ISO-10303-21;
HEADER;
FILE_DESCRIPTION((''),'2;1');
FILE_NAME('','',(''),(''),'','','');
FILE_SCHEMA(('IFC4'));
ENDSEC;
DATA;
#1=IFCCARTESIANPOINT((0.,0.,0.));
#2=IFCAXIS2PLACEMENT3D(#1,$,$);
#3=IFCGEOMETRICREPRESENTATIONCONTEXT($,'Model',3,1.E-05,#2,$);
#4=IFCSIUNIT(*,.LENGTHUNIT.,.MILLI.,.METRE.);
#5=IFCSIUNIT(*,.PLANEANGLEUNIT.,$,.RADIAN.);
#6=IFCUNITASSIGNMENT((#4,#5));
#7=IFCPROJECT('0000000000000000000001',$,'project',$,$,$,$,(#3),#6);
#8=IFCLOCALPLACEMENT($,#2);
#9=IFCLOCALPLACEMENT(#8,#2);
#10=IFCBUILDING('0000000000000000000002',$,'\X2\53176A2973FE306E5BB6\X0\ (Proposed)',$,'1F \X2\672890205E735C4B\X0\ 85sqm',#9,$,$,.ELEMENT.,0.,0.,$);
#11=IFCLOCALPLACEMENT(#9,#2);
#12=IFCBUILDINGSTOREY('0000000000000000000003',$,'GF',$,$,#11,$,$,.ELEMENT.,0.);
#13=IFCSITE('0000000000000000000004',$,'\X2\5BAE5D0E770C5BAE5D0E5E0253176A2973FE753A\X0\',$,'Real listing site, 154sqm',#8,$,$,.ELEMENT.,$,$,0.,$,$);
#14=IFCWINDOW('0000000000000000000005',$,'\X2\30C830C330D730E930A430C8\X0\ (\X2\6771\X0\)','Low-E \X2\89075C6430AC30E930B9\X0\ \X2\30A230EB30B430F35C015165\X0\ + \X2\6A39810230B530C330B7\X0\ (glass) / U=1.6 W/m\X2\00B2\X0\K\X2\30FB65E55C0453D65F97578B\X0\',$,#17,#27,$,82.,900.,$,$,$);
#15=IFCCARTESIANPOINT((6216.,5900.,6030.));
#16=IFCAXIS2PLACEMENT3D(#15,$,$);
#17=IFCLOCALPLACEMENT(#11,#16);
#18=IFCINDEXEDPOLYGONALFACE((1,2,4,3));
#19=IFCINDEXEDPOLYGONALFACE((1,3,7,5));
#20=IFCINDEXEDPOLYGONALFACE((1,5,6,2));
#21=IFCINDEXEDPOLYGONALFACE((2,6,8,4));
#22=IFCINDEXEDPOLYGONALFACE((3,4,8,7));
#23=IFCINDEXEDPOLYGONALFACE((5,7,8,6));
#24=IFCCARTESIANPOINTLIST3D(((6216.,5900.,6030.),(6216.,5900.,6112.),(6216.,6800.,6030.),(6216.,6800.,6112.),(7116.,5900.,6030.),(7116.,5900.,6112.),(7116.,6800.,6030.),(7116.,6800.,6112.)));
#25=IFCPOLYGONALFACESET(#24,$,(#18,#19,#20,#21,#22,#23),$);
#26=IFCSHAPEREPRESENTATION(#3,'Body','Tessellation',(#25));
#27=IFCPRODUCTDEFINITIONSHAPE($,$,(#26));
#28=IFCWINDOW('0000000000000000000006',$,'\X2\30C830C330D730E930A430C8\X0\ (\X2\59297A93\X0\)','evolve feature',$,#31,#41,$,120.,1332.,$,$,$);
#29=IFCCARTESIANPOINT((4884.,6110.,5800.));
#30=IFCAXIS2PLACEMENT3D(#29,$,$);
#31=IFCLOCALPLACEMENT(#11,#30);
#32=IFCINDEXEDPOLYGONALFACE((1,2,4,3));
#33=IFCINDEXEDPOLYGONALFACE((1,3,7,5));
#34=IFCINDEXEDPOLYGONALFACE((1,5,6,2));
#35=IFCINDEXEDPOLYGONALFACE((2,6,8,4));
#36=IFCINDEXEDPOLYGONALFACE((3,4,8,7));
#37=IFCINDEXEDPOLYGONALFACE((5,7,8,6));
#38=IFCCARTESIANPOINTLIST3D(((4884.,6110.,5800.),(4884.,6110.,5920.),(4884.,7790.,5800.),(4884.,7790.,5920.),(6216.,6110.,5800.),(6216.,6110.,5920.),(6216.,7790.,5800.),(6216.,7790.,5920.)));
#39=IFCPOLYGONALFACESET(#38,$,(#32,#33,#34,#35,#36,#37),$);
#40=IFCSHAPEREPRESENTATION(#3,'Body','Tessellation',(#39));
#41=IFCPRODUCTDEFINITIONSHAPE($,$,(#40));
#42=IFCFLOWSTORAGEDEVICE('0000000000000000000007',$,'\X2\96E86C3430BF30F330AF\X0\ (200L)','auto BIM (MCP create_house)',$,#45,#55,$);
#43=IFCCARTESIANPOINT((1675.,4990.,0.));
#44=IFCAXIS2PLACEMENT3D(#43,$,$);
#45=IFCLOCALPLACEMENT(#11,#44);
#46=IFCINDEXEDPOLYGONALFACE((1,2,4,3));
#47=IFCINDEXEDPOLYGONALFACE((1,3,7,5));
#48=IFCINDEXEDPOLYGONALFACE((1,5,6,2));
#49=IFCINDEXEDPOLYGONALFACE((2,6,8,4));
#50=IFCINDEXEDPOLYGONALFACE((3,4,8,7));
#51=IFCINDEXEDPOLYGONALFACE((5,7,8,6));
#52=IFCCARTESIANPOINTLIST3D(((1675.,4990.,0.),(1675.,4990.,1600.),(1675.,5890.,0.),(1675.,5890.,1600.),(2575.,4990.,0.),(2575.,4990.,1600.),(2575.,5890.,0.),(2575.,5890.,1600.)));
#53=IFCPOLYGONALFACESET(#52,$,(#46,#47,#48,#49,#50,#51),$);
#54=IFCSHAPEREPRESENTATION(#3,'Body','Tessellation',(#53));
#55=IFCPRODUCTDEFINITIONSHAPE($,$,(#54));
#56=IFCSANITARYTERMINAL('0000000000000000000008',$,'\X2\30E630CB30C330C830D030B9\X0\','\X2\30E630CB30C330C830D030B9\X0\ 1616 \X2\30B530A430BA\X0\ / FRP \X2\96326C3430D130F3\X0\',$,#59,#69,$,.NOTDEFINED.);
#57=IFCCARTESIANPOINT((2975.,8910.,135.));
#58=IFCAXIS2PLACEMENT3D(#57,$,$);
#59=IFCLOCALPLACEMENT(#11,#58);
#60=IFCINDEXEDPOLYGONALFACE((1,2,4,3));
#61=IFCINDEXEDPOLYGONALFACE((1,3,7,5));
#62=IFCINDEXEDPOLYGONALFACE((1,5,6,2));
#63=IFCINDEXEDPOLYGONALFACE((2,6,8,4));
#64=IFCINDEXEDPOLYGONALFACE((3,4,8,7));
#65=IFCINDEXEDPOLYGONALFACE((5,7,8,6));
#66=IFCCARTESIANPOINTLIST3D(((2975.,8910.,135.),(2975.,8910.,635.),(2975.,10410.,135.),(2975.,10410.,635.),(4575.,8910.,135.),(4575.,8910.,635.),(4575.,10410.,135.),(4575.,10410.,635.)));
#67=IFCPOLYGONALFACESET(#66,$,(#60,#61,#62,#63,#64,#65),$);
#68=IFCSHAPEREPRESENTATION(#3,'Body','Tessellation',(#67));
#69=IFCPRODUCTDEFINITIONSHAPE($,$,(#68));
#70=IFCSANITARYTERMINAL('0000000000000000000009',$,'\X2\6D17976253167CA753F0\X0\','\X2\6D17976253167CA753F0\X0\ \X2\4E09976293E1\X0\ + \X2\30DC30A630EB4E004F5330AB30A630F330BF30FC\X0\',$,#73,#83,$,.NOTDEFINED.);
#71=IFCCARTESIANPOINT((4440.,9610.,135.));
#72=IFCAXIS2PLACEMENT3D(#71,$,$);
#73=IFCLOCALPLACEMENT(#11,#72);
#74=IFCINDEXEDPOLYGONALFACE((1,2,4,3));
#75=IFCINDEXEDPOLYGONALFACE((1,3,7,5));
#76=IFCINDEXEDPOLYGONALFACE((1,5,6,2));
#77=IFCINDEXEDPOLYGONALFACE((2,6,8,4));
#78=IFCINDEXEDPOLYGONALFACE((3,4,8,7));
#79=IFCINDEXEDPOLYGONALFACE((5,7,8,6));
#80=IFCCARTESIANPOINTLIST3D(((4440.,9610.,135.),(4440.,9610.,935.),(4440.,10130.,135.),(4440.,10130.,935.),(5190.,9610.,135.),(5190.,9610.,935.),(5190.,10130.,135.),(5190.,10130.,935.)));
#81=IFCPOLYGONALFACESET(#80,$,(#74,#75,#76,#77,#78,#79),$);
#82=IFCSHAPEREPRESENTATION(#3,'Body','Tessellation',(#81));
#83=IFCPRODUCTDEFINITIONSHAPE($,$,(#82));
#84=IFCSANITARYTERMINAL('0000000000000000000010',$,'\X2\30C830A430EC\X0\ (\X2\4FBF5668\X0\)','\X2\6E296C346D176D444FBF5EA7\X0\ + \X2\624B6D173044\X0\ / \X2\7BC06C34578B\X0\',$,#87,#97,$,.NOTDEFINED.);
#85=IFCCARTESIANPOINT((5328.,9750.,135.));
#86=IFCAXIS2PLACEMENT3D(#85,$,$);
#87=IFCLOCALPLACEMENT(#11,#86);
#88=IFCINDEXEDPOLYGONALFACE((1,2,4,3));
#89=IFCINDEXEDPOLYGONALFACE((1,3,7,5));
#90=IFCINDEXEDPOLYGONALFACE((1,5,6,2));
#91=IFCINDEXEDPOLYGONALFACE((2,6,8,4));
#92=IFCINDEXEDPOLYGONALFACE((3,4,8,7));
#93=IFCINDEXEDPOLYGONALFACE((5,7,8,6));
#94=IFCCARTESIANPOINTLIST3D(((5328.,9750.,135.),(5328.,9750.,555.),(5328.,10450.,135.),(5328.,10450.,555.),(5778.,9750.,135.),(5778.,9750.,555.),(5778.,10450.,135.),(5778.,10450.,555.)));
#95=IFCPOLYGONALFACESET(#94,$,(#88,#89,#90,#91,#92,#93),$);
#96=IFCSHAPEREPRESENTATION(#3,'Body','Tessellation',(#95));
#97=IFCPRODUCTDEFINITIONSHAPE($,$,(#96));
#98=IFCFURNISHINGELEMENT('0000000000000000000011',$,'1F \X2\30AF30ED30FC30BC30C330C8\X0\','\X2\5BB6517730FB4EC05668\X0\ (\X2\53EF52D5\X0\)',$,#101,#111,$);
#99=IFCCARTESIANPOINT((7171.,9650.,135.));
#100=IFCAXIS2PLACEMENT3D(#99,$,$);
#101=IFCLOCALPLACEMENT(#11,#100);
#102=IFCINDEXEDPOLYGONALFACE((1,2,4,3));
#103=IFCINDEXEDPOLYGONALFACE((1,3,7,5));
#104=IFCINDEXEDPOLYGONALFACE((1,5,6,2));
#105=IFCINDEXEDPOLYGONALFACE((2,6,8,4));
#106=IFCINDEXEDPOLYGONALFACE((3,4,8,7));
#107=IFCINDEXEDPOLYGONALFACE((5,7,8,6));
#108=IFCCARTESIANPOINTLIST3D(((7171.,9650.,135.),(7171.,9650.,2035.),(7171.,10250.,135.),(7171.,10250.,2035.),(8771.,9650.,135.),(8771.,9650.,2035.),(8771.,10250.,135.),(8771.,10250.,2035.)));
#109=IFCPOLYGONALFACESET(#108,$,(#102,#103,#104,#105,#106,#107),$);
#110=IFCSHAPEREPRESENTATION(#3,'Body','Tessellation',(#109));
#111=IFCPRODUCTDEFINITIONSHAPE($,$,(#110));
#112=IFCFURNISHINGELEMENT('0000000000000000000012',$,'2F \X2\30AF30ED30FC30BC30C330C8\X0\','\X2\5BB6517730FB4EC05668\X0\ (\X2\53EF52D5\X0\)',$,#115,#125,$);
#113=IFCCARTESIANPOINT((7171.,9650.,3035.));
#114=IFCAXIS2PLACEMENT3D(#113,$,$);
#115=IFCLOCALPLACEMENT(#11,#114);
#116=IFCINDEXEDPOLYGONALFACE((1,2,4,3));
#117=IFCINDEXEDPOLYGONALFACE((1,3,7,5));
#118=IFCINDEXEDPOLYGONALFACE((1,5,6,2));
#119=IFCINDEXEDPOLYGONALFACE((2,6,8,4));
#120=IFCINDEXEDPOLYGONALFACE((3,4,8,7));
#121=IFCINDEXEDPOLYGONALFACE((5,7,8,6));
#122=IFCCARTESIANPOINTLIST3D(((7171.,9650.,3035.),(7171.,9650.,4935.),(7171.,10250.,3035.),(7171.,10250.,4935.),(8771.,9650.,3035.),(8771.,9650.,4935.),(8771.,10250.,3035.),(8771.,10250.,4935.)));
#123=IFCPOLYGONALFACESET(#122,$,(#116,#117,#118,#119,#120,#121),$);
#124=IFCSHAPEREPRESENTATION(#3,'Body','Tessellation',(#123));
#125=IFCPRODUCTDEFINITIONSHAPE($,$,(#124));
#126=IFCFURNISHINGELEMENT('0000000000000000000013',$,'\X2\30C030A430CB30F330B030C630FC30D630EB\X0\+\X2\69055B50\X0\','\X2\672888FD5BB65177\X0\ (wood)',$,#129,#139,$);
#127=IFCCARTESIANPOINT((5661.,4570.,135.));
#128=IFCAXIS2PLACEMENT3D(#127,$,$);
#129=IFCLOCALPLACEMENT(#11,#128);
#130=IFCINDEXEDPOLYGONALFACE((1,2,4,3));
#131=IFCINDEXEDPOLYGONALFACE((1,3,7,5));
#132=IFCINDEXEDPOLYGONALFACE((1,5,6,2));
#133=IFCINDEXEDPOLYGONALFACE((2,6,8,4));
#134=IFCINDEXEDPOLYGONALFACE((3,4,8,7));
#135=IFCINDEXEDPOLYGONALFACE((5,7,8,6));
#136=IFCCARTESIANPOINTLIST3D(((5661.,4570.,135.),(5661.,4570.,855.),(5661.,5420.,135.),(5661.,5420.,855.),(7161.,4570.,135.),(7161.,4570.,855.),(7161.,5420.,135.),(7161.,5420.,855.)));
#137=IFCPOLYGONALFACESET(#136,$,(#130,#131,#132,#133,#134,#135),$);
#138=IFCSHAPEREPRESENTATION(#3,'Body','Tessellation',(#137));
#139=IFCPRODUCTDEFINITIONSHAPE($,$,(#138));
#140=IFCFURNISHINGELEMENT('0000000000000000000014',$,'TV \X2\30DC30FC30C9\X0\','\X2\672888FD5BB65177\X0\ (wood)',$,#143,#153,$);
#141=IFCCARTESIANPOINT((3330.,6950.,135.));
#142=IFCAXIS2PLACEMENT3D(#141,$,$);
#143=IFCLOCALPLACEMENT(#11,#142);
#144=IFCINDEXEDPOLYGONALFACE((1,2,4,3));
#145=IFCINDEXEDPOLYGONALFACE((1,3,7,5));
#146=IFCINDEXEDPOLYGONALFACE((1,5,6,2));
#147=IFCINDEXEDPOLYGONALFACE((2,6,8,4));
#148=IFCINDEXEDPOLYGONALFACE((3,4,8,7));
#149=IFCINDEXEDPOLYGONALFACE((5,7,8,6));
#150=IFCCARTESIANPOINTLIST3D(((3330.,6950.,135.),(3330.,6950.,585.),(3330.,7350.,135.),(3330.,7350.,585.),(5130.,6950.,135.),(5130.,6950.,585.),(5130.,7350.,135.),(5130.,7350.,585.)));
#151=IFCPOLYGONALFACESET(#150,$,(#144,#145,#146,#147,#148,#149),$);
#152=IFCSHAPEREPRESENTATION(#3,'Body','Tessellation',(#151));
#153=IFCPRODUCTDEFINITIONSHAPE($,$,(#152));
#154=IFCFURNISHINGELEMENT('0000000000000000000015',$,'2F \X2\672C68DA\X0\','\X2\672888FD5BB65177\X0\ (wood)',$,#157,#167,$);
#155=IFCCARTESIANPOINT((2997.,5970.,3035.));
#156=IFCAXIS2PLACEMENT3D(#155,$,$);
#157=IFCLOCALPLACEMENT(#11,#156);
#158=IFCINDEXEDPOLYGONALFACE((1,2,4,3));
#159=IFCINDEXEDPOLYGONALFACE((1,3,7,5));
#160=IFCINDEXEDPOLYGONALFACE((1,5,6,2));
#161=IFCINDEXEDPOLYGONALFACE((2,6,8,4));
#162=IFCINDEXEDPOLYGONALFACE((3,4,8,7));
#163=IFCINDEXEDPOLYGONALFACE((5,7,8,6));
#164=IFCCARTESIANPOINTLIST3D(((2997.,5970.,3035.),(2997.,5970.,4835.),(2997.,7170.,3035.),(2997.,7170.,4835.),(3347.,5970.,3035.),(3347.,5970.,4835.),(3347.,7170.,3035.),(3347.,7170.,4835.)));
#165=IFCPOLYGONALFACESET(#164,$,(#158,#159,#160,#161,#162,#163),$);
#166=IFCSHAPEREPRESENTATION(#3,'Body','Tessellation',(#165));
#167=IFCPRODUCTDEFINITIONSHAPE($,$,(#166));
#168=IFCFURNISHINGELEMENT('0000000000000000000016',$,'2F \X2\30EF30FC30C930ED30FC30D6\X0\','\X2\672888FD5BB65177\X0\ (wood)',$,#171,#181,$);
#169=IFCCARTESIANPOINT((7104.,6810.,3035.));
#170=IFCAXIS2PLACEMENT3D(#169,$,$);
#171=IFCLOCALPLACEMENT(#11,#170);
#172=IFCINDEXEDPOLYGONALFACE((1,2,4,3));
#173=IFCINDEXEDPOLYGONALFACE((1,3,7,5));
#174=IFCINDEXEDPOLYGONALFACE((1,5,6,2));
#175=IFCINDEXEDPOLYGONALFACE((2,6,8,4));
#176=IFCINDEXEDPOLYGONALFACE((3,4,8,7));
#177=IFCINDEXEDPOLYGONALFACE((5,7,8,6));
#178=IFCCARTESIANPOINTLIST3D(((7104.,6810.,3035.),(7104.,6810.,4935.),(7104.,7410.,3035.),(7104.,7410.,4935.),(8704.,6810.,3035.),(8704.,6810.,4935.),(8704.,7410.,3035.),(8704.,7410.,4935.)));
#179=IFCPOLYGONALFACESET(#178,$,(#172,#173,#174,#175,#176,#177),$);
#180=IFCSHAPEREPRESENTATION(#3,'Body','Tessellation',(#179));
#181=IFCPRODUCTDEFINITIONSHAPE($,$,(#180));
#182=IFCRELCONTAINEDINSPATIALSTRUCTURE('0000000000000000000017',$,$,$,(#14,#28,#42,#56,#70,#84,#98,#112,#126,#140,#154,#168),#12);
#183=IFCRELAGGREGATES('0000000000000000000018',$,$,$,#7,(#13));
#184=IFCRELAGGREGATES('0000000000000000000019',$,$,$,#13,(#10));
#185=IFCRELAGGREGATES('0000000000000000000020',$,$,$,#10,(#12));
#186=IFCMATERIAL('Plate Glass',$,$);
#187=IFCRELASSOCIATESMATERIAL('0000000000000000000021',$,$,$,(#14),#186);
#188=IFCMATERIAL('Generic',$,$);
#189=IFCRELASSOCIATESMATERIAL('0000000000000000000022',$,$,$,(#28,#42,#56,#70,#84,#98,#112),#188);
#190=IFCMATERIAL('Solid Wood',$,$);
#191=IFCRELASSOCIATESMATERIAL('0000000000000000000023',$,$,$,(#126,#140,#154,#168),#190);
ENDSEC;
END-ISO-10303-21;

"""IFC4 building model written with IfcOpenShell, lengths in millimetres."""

from ifc_helpers import new_model, si_unit, frame, frame_2d, origin, place, context, project, spatial, rectangle, extrude, material, element, save


model = new_model("IFC4")

# Units and contexts
model_context = context("Model", 3, precision=1e-05, world=origin())
ifc_project = project(units=[si_unit("LENGTHUNIT", "METRE", prefix="MILLI"), si_unit("PLANEANGLEUNIT", "RADIAN")], contexts=[model_context])

# Site, building, storey
site_placement = place(None, origin())
site = spatial("IfcSite", under=ifc_project, at=site_placement, Name="宮崎県宮崎市北権現町", ObjectType="Real listing site, 154sqm", CompositionType="ELEMENT", RefElevation=0.0)
building_placement = place(site_placement, origin())
building = spatial("IfcBuilding", under=site, at=building_placement, Name="北権現の家 (Proposed)", ObjectType="1F 木造平屋 85sqm", CompositionType="ELEMENT", ElevationOfRefHeight=0.0, ElevationOfTerrain=0.0)
storey_placement = place(building_placement, origin())
storey = spatial("IfcBuildingStorey", under=building, at=storey_placement, Name="GF", CompositionType="ELEMENT", Elevation=0.0)

# Shared definitions
ifc_material_1 = material(Name="Solid Wood")
ifc_material_2 = material(Name="Plate Glass")

# Windows
window_1_placement = place(storey_placement, frame((6216.0, 5900.0, 6030.0)))
element("IfcWindow", 1, at=window_1_placement, inside=storey, material=ifc_material_2, Name="トップライト (東)", Description="Low-E 複層ガラス アルゴン封入 + 樹脂サッシ (glass) / U=1.6 W/m²K・日射取得型", OverallHeight=82.0, OverallWidth=900.0, context=model_context, shape_type="SweptSolid", body=[
    extrude(rectangle(XDim=900.0, YDim=900.0, at=frame_2d((450.0, 450.0))), frame((6216.0, 5900.0, 6030.0)), (0.0, 0.0, 1.0), 82.0),
])
ifc_material_3 = material(Name="Generic")
window_2_placement = place(storey_placement, frame((4884.0, 6110.0, 5800.0)))
element("IfcWindow", 2, at=window_2_placement, inside=storey, material=ifc_material_3, Name="トップライト (天窓)", Description="evolve feature", OverallHeight=120.0, OverallWidth=1332.0, context=model_context, shape_type="SweptSolid", body=[
    extrude(rectangle(XDim=1332.0, YDim=1680.0, at=frame_2d((666.0, 840.0))), frame((4884.0, 6110.0, 5800.0)), (0.0, 0.0, 1.0), 120.0),
])

# Flow storage device
flow_storage_device_placement = place(storey_placement, frame((1675.0, 4990.0, 0.0)))
element("IfcFlowStorageDevice", 3, at=flow_storage_device_placement, inside=storey, material=ifc_material_3, Name="雨水タンク (200L)", Description="auto BIM (MCP create_house)", context=model_context, shape_type="SweptSolid", body=[
    extrude(rectangle(XDim=900.0, YDim=900.0, at=frame_2d((450.0, 450.0))), frame((1675.0, 4990.0, 0.0)), (0.0, 0.0, 1.0), 1600.0),
])

# Sanitary terminals
sanitary_terminal_1_placement = place(storey_placement, frame((2975.0, 8910.0, 135.0)))
element("IfcSanitaryTerminal", 4, at=sanitary_terminal_1_placement, inside=storey, material=ifc_material_3, Name="ユニットバス", Description="ユニットバス 1616 サイズ / FRP 防水パン", PredefinedType="NOTDEFINED", context=model_context, shape_type="SweptSolid", body=[
    extrude(rectangle(XDim=1600.0, YDim=1500.0, at=frame_2d((800.0, 750.0))), frame((2975.0, 8910.0, 135.0)), (0.0, 0.0, 1.0), 500.0),
])
sanitary_terminal_2_placement = place(storey_placement, frame((4440.0, 9610.0, 135.0)))
element("IfcSanitaryTerminal", 5, at=sanitary_terminal_2_placement, inside=storey, material=ifc_material_3, Name="洗面化粧台", Description="洗面化粧台 三面鏡 + ボウル一体カウンター", PredefinedType="NOTDEFINED", context=model_context, shape_type="SweptSolid", body=[
    extrude(rectangle(XDim=750.0, YDim=520.0, at=frame_2d((375.0, 260.0))), frame((4440.0, 9610.0, 135.0)), (0.0, 0.0, 1.0), 800.0),
])
sanitary_terminal_3_placement = place(storey_placement, frame((5328.0, 9750.0, 135.0)))
element("IfcSanitaryTerminal", 6, at=sanitary_terminal_3_placement, inside=storey, material=ifc_material_3, Name="トイレ (便器)", Description="温水洗浄便座 + 手洗い / 節水型", PredefinedType="NOTDEFINED", context=model_context, shape_type="SweptSolid", body=[
    extrude(rectangle(XDim=450.0, YDim=700.0, at=frame_2d((225.0, 350.0))), frame((5328.0, 9750.0, 135.0)), (0.0, 0.0, 1.0), 420.0),
])

# Furnishing elements
furnishing_1_placement = place(storey_placement, frame((7171.0, 9650.0, 135.0)))
element("IfcFurnishingElement", 7, at=furnishing_1_placement, inside=storey, material=ifc_material_3, Name="1F クローゼット", Description="家具・什器 (可動)", context=model_context, shape_type="SweptSolid", body=[
    extrude(rectangle(XDim=1600.0, YDim=600.0, at=frame_2d((800.0, 300.0))), frame((7171.0, 9650.0, 135.0)), (0.0, 0.0, 1.0), 1900.0),
])
furnishing_2_placement = place(storey_placement, frame((7171.0, 9650.0, 3035.0)))
element("IfcFurnishingElement", 8, at=furnishing_2_placement, inside=storey, material=ifc_material_3, Name="2F クローゼット", Description="家具・什器 (可動)", context=model_context, shape_type="SweptSolid", body=[
    extrude(rectangle(XDim=1600.0, YDim=600.0, at=frame_2d((800.0, 300.0))), frame((7171.0, 9650.0, 3035.0)), (0.0, 0.0, 1.0), 1900.0),
])
furnishing_3_placement = place(storey_placement, frame((5661.0, 4570.0, 135.0)))
element("IfcFurnishingElement", 9, at=furnishing_3_placement, inside=storey, material=ifc_material_1, Name="ダイニングテーブル+椅子", Description="木製家具 (wood)", context=model_context, shape_type="SweptSolid", body=[
    extrude(rectangle(XDim=1500.0, YDim=850.0, at=frame_2d((750.0, 425.0))), frame((5661.0, 4570.0, 135.0)), (0.0, 0.0, 1.0), 720.0),
])
furnishing_4_placement = place(storey_placement, frame((3330.0, 6950.0, 135.0)))
element("IfcFurnishingElement", 10, at=furnishing_4_placement, inside=storey, material=ifc_material_1, Name="TV ボード", Description="木製家具 (wood)", context=model_context, shape_type="SweptSolid", body=[
    extrude(rectangle(XDim=1800.0, YDim=400.0, at=frame_2d((900.0, 200.0))), frame((3330.0, 6950.0, 135.0)), (0.0, 0.0, 1.0), 450.0),
])
furnishing_5_placement = place(storey_placement, frame((2997.0, 5970.0, 3035.0)))
element("IfcFurnishingElement", 11, at=furnishing_5_placement, inside=storey, material=ifc_material_1, Name="2F 本棚", Description="木製家具 (wood)", context=model_context, shape_type="SweptSolid", body=[
    extrude(rectangle(XDim=350.0, YDim=1200.0, at=frame_2d((175.0, 600.0))), frame((2997.0, 5970.0, 3035.0)), (0.0, 0.0, 1.0), 1800.0),
])
furnishing_6_placement = place(storey_placement, frame((7104.0, 6810.0, 3035.0)))
element("IfcFurnishingElement", 12, at=furnishing_6_placement, inside=storey, material=ifc_material_1, Name="2F ワードローブ", Description="木製家具 (wood)", context=model_context, shape_type="SweptSolid", body=[
    extrude(rectangle(XDim=1600.0, YDim=600.0, at=frame_2d((800.0, 300.0))), frame((7104.0, 6810.0, 3035.0)), (0.0, 0.0, 1.0), 1900.0),
])

save(model, "model.ifc")
